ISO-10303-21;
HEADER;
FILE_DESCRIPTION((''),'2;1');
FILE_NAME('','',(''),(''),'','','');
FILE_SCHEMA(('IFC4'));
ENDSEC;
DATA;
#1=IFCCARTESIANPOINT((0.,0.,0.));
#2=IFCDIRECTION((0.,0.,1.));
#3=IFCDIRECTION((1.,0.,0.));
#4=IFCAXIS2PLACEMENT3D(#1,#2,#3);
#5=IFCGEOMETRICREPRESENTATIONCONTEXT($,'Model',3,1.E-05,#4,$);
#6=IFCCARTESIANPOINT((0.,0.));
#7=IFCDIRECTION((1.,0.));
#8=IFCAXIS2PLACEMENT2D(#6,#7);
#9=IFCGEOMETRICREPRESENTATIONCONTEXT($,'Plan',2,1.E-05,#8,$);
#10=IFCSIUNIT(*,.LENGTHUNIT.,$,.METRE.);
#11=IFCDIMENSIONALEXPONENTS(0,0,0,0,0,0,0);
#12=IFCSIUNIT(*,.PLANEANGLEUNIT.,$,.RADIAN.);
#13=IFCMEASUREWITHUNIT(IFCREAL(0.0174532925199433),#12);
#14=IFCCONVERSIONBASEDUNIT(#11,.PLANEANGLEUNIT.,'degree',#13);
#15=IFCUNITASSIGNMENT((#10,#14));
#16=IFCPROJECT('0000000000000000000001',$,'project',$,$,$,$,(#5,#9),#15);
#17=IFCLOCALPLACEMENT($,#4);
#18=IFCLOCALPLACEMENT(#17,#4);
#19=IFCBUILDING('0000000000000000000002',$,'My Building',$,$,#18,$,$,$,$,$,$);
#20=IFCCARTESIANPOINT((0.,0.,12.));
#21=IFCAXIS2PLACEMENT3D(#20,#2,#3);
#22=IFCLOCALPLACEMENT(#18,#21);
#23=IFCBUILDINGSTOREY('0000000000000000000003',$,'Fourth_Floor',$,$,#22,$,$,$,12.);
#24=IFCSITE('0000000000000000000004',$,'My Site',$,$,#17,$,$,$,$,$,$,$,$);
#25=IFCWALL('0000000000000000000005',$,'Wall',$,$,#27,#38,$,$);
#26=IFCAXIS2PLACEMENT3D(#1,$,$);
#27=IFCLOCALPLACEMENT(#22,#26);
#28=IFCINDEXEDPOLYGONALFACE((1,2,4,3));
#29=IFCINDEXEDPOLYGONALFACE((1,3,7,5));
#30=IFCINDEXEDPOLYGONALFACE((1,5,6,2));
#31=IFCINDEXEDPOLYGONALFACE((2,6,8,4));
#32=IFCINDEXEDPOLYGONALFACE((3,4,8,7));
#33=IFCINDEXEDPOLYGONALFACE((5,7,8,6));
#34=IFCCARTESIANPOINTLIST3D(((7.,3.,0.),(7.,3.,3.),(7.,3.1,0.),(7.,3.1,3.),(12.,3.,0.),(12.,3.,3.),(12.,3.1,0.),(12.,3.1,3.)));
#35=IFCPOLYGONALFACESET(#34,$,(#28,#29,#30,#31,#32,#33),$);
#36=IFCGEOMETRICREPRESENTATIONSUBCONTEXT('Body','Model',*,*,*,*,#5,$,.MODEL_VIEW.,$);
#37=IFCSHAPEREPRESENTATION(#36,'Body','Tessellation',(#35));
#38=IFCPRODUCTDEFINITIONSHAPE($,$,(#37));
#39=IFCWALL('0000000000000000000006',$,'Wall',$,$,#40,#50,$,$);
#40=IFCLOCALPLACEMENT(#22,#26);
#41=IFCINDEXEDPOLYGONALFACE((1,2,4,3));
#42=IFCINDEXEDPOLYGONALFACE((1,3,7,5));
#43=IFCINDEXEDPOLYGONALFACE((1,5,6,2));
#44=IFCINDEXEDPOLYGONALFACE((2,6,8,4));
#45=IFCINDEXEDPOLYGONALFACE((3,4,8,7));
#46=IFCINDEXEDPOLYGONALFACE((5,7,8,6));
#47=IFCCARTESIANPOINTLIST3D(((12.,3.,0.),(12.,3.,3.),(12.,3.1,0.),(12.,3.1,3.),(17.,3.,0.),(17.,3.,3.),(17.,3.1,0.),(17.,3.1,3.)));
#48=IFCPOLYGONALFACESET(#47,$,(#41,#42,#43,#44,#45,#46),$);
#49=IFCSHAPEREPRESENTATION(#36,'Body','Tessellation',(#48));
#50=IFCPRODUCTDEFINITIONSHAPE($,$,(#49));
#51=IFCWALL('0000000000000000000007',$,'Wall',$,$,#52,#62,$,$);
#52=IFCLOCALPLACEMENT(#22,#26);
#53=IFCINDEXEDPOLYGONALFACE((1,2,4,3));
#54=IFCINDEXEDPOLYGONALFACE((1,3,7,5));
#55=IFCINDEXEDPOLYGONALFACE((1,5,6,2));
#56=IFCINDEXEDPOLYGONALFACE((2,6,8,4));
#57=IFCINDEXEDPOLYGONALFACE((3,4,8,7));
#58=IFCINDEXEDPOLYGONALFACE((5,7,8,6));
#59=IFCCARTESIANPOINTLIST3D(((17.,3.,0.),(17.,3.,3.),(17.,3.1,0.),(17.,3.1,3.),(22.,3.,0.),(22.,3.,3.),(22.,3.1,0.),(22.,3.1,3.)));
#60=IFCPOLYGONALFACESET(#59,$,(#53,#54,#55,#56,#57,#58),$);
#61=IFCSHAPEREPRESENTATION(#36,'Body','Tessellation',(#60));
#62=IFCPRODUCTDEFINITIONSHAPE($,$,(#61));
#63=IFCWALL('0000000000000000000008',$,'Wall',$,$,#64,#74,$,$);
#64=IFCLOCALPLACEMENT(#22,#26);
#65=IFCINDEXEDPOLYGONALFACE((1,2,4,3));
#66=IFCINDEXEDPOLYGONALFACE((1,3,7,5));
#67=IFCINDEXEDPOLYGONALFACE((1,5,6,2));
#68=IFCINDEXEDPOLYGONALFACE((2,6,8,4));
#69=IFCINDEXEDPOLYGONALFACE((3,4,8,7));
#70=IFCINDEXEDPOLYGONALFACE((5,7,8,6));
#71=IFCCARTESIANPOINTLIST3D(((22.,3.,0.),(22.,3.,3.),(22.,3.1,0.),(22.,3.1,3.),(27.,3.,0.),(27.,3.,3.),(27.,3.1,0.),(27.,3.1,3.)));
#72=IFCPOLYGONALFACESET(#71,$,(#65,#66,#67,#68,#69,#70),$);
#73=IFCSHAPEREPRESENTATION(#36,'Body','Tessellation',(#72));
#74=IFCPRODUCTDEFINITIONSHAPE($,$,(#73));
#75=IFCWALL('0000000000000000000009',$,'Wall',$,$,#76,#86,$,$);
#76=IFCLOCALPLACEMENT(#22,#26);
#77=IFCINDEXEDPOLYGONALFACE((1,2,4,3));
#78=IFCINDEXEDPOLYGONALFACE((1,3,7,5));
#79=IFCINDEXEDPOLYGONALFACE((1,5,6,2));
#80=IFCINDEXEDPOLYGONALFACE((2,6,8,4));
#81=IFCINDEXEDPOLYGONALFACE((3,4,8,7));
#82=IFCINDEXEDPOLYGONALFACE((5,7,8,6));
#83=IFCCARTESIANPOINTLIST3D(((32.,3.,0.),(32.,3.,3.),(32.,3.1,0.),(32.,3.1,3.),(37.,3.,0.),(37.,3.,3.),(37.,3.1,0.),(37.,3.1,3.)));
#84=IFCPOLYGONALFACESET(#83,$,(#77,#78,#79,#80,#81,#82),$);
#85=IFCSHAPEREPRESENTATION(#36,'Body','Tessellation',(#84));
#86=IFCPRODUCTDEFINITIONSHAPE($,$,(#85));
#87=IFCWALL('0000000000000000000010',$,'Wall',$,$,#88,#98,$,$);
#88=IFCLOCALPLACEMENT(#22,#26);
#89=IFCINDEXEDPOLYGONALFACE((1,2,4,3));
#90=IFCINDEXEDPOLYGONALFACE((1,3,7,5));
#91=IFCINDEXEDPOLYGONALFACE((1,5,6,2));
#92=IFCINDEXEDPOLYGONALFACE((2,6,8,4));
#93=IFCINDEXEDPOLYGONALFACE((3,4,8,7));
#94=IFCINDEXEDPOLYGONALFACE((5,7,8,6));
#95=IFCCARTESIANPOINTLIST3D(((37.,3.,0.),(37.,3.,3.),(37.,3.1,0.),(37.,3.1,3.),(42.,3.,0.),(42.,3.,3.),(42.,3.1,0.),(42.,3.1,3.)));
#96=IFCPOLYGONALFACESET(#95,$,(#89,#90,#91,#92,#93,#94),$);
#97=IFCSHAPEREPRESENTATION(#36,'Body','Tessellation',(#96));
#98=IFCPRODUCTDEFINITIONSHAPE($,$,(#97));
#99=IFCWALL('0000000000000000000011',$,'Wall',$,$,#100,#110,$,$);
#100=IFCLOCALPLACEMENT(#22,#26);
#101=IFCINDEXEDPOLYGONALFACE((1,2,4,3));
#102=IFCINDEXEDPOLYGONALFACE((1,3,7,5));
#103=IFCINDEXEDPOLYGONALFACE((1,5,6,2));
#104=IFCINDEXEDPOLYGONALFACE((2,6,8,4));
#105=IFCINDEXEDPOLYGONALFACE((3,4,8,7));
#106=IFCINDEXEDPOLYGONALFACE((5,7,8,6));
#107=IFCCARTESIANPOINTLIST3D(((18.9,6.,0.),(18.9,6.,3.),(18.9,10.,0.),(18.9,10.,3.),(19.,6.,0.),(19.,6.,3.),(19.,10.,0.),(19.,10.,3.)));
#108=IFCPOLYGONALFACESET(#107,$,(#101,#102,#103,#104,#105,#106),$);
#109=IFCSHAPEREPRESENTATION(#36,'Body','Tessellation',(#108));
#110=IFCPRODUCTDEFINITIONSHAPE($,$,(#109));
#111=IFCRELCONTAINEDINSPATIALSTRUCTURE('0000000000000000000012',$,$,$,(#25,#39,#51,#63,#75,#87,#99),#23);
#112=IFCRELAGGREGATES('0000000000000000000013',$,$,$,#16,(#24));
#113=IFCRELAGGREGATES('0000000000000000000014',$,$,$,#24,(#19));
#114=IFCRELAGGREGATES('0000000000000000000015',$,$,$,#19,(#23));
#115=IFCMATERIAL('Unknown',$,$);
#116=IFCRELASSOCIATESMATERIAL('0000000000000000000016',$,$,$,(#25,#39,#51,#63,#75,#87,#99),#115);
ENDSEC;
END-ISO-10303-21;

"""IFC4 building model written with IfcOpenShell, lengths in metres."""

from ifc_helpers import new_model, entity, si_unit, converted_unit, frame, frame_2d, origin, origin_with_axes, origin_2d_with_axis, place, context, subcontext, project, spatial, rectangle, extrude, material, element, save


model = new_model("IFC4")

# Units and contexts
model_context = context("Model", 3, precision=1e-05, world=origin_with_axes())
plan_context = context("Plan", 2, precision=1e-05, world=origin_2d_with_axis())
body_context = subcontext(model_context, "Body", "Model", "MODEL_VIEW")
ifc_project = project(units=[si_unit("LENGTHUNIT", "METRE"), converted_unit("PLANEANGLEUNIT", "degree", entity("IfcReal", 0.0174532925199433), si_unit("PLANEANGLEUNIT", "RADIAN"), dimensions=[0, 0, 0, 0, 0, 0, 0])], contexts=[model_context, plan_context])

# Site, building, storey
site_placement = place(None, origin_with_axes())
site = spatial("IfcSite", under=ifc_project, at=site_placement, Name="My Site")
building_placement = place(site_placement, origin_with_axes())
building = spatial("IfcBuilding", under=site, at=building_placement, Name="My Building")
storey_placement = place(building_placement, frame((0.0, 0.0, 12.0), z_axis=(0.0, 0.0, 1.0), x_axis=(1.0, 0.0, 0.0)))
storey = spatial("IfcBuildingStorey", under=building, at=storey_placement, Name="Fourth_Floor", Elevation=12.0)

# Walls
ifc_material = material(Name="Unknown")
wall_1_placement = place(storey_placement, origin_with_axes())
element("IfcWall", 1, at=wall_1_placement, inside=storey, material=ifc_material, Name="Wall", context=body_context, shape_type="SweptSolid", body=[
    extrude(rectangle(XDim=5.0, YDim=0.1, at=frame_2d((9.5, 3.05))), origin(), (0.0, 0.0, 1.0), 3.0),
])
wall_2_placement = place(storey_placement, origin_with_axes())
element("IfcWall", 2, at=wall_2_placement, inside=storey, material=ifc_material, Name="Wall", context=body_context, shape_type="SweptSolid", body=[
    extrude(rectangle(XDim=5.0, YDim=0.1, at=frame_2d((14.5, 3.05))), origin(), (0.0, 0.0, 1.0), 3.0),
])
wall_3_placement = place(storey_placement, origin_with_axes())
element("IfcWall", 3, at=wall_3_placement, inside=storey, material=ifc_material, Name="Wall", context=body_context, shape_type="SweptSolid", body=[
    extrude(rectangle(XDim=5.0, YDim=0.1, at=frame_2d((19.5, 3.05))), origin(), (0.0, 0.0, 1.0), 3.0),
])
wall_4_placement = place(storey_placement, origin_with_axes())
element("IfcWall", 4, at=wall_4_placement, inside=storey, material=ifc_material, Name="Wall", context=body_context, shape_type="SweptSolid", body=[
    extrude(rectangle(XDim=5.0, YDim=0.1, at=frame_2d((24.5, 3.05))), origin(), (0.0, 0.0, 1.0), 3.0),
])
wall_5_placement = place(storey_placement, origin_with_axes())
element("IfcWall", 5, at=wall_5_placement, inside=storey, material=ifc_material, Name="Wall", context=body_context, shape_type="SweptSolid", body=[
    extrude(rectangle(XDim=5.0, YDim=0.1, at=frame_2d((34.5, 3.05))), origin(), (0.0, 0.0, 1.0), 3.0),
])
wall_6_placement = place(storey_placement, origin_with_axes())
element("IfcWall", 6, at=wall_6_placement, inside=storey, material=ifc_material, Name="Wall", context=body_context, shape_type="SweptSolid", body=[
    extrude(rectangle(XDim=5.0, YDim=0.1, at=frame_2d((39.5, 3.05))), origin(), (0.0, 0.0, 1.0), 3.0),
])
wall_7_placement = place(storey_placement, origin_with_axes())
element("IfcWall", 7, at=wall_7_placement, inside=storey, material=ifc_material, Name="Wall", context=body_context, shape_type="SweptSolid", body=[
    extrude(rectangle(XDim=0.1, YDim=4.0, at=frame_2d((18.95, 8.0))), origin(), (0.0, 0.0, 1.0), 3.0),
])

save(model, "model.ifc")
